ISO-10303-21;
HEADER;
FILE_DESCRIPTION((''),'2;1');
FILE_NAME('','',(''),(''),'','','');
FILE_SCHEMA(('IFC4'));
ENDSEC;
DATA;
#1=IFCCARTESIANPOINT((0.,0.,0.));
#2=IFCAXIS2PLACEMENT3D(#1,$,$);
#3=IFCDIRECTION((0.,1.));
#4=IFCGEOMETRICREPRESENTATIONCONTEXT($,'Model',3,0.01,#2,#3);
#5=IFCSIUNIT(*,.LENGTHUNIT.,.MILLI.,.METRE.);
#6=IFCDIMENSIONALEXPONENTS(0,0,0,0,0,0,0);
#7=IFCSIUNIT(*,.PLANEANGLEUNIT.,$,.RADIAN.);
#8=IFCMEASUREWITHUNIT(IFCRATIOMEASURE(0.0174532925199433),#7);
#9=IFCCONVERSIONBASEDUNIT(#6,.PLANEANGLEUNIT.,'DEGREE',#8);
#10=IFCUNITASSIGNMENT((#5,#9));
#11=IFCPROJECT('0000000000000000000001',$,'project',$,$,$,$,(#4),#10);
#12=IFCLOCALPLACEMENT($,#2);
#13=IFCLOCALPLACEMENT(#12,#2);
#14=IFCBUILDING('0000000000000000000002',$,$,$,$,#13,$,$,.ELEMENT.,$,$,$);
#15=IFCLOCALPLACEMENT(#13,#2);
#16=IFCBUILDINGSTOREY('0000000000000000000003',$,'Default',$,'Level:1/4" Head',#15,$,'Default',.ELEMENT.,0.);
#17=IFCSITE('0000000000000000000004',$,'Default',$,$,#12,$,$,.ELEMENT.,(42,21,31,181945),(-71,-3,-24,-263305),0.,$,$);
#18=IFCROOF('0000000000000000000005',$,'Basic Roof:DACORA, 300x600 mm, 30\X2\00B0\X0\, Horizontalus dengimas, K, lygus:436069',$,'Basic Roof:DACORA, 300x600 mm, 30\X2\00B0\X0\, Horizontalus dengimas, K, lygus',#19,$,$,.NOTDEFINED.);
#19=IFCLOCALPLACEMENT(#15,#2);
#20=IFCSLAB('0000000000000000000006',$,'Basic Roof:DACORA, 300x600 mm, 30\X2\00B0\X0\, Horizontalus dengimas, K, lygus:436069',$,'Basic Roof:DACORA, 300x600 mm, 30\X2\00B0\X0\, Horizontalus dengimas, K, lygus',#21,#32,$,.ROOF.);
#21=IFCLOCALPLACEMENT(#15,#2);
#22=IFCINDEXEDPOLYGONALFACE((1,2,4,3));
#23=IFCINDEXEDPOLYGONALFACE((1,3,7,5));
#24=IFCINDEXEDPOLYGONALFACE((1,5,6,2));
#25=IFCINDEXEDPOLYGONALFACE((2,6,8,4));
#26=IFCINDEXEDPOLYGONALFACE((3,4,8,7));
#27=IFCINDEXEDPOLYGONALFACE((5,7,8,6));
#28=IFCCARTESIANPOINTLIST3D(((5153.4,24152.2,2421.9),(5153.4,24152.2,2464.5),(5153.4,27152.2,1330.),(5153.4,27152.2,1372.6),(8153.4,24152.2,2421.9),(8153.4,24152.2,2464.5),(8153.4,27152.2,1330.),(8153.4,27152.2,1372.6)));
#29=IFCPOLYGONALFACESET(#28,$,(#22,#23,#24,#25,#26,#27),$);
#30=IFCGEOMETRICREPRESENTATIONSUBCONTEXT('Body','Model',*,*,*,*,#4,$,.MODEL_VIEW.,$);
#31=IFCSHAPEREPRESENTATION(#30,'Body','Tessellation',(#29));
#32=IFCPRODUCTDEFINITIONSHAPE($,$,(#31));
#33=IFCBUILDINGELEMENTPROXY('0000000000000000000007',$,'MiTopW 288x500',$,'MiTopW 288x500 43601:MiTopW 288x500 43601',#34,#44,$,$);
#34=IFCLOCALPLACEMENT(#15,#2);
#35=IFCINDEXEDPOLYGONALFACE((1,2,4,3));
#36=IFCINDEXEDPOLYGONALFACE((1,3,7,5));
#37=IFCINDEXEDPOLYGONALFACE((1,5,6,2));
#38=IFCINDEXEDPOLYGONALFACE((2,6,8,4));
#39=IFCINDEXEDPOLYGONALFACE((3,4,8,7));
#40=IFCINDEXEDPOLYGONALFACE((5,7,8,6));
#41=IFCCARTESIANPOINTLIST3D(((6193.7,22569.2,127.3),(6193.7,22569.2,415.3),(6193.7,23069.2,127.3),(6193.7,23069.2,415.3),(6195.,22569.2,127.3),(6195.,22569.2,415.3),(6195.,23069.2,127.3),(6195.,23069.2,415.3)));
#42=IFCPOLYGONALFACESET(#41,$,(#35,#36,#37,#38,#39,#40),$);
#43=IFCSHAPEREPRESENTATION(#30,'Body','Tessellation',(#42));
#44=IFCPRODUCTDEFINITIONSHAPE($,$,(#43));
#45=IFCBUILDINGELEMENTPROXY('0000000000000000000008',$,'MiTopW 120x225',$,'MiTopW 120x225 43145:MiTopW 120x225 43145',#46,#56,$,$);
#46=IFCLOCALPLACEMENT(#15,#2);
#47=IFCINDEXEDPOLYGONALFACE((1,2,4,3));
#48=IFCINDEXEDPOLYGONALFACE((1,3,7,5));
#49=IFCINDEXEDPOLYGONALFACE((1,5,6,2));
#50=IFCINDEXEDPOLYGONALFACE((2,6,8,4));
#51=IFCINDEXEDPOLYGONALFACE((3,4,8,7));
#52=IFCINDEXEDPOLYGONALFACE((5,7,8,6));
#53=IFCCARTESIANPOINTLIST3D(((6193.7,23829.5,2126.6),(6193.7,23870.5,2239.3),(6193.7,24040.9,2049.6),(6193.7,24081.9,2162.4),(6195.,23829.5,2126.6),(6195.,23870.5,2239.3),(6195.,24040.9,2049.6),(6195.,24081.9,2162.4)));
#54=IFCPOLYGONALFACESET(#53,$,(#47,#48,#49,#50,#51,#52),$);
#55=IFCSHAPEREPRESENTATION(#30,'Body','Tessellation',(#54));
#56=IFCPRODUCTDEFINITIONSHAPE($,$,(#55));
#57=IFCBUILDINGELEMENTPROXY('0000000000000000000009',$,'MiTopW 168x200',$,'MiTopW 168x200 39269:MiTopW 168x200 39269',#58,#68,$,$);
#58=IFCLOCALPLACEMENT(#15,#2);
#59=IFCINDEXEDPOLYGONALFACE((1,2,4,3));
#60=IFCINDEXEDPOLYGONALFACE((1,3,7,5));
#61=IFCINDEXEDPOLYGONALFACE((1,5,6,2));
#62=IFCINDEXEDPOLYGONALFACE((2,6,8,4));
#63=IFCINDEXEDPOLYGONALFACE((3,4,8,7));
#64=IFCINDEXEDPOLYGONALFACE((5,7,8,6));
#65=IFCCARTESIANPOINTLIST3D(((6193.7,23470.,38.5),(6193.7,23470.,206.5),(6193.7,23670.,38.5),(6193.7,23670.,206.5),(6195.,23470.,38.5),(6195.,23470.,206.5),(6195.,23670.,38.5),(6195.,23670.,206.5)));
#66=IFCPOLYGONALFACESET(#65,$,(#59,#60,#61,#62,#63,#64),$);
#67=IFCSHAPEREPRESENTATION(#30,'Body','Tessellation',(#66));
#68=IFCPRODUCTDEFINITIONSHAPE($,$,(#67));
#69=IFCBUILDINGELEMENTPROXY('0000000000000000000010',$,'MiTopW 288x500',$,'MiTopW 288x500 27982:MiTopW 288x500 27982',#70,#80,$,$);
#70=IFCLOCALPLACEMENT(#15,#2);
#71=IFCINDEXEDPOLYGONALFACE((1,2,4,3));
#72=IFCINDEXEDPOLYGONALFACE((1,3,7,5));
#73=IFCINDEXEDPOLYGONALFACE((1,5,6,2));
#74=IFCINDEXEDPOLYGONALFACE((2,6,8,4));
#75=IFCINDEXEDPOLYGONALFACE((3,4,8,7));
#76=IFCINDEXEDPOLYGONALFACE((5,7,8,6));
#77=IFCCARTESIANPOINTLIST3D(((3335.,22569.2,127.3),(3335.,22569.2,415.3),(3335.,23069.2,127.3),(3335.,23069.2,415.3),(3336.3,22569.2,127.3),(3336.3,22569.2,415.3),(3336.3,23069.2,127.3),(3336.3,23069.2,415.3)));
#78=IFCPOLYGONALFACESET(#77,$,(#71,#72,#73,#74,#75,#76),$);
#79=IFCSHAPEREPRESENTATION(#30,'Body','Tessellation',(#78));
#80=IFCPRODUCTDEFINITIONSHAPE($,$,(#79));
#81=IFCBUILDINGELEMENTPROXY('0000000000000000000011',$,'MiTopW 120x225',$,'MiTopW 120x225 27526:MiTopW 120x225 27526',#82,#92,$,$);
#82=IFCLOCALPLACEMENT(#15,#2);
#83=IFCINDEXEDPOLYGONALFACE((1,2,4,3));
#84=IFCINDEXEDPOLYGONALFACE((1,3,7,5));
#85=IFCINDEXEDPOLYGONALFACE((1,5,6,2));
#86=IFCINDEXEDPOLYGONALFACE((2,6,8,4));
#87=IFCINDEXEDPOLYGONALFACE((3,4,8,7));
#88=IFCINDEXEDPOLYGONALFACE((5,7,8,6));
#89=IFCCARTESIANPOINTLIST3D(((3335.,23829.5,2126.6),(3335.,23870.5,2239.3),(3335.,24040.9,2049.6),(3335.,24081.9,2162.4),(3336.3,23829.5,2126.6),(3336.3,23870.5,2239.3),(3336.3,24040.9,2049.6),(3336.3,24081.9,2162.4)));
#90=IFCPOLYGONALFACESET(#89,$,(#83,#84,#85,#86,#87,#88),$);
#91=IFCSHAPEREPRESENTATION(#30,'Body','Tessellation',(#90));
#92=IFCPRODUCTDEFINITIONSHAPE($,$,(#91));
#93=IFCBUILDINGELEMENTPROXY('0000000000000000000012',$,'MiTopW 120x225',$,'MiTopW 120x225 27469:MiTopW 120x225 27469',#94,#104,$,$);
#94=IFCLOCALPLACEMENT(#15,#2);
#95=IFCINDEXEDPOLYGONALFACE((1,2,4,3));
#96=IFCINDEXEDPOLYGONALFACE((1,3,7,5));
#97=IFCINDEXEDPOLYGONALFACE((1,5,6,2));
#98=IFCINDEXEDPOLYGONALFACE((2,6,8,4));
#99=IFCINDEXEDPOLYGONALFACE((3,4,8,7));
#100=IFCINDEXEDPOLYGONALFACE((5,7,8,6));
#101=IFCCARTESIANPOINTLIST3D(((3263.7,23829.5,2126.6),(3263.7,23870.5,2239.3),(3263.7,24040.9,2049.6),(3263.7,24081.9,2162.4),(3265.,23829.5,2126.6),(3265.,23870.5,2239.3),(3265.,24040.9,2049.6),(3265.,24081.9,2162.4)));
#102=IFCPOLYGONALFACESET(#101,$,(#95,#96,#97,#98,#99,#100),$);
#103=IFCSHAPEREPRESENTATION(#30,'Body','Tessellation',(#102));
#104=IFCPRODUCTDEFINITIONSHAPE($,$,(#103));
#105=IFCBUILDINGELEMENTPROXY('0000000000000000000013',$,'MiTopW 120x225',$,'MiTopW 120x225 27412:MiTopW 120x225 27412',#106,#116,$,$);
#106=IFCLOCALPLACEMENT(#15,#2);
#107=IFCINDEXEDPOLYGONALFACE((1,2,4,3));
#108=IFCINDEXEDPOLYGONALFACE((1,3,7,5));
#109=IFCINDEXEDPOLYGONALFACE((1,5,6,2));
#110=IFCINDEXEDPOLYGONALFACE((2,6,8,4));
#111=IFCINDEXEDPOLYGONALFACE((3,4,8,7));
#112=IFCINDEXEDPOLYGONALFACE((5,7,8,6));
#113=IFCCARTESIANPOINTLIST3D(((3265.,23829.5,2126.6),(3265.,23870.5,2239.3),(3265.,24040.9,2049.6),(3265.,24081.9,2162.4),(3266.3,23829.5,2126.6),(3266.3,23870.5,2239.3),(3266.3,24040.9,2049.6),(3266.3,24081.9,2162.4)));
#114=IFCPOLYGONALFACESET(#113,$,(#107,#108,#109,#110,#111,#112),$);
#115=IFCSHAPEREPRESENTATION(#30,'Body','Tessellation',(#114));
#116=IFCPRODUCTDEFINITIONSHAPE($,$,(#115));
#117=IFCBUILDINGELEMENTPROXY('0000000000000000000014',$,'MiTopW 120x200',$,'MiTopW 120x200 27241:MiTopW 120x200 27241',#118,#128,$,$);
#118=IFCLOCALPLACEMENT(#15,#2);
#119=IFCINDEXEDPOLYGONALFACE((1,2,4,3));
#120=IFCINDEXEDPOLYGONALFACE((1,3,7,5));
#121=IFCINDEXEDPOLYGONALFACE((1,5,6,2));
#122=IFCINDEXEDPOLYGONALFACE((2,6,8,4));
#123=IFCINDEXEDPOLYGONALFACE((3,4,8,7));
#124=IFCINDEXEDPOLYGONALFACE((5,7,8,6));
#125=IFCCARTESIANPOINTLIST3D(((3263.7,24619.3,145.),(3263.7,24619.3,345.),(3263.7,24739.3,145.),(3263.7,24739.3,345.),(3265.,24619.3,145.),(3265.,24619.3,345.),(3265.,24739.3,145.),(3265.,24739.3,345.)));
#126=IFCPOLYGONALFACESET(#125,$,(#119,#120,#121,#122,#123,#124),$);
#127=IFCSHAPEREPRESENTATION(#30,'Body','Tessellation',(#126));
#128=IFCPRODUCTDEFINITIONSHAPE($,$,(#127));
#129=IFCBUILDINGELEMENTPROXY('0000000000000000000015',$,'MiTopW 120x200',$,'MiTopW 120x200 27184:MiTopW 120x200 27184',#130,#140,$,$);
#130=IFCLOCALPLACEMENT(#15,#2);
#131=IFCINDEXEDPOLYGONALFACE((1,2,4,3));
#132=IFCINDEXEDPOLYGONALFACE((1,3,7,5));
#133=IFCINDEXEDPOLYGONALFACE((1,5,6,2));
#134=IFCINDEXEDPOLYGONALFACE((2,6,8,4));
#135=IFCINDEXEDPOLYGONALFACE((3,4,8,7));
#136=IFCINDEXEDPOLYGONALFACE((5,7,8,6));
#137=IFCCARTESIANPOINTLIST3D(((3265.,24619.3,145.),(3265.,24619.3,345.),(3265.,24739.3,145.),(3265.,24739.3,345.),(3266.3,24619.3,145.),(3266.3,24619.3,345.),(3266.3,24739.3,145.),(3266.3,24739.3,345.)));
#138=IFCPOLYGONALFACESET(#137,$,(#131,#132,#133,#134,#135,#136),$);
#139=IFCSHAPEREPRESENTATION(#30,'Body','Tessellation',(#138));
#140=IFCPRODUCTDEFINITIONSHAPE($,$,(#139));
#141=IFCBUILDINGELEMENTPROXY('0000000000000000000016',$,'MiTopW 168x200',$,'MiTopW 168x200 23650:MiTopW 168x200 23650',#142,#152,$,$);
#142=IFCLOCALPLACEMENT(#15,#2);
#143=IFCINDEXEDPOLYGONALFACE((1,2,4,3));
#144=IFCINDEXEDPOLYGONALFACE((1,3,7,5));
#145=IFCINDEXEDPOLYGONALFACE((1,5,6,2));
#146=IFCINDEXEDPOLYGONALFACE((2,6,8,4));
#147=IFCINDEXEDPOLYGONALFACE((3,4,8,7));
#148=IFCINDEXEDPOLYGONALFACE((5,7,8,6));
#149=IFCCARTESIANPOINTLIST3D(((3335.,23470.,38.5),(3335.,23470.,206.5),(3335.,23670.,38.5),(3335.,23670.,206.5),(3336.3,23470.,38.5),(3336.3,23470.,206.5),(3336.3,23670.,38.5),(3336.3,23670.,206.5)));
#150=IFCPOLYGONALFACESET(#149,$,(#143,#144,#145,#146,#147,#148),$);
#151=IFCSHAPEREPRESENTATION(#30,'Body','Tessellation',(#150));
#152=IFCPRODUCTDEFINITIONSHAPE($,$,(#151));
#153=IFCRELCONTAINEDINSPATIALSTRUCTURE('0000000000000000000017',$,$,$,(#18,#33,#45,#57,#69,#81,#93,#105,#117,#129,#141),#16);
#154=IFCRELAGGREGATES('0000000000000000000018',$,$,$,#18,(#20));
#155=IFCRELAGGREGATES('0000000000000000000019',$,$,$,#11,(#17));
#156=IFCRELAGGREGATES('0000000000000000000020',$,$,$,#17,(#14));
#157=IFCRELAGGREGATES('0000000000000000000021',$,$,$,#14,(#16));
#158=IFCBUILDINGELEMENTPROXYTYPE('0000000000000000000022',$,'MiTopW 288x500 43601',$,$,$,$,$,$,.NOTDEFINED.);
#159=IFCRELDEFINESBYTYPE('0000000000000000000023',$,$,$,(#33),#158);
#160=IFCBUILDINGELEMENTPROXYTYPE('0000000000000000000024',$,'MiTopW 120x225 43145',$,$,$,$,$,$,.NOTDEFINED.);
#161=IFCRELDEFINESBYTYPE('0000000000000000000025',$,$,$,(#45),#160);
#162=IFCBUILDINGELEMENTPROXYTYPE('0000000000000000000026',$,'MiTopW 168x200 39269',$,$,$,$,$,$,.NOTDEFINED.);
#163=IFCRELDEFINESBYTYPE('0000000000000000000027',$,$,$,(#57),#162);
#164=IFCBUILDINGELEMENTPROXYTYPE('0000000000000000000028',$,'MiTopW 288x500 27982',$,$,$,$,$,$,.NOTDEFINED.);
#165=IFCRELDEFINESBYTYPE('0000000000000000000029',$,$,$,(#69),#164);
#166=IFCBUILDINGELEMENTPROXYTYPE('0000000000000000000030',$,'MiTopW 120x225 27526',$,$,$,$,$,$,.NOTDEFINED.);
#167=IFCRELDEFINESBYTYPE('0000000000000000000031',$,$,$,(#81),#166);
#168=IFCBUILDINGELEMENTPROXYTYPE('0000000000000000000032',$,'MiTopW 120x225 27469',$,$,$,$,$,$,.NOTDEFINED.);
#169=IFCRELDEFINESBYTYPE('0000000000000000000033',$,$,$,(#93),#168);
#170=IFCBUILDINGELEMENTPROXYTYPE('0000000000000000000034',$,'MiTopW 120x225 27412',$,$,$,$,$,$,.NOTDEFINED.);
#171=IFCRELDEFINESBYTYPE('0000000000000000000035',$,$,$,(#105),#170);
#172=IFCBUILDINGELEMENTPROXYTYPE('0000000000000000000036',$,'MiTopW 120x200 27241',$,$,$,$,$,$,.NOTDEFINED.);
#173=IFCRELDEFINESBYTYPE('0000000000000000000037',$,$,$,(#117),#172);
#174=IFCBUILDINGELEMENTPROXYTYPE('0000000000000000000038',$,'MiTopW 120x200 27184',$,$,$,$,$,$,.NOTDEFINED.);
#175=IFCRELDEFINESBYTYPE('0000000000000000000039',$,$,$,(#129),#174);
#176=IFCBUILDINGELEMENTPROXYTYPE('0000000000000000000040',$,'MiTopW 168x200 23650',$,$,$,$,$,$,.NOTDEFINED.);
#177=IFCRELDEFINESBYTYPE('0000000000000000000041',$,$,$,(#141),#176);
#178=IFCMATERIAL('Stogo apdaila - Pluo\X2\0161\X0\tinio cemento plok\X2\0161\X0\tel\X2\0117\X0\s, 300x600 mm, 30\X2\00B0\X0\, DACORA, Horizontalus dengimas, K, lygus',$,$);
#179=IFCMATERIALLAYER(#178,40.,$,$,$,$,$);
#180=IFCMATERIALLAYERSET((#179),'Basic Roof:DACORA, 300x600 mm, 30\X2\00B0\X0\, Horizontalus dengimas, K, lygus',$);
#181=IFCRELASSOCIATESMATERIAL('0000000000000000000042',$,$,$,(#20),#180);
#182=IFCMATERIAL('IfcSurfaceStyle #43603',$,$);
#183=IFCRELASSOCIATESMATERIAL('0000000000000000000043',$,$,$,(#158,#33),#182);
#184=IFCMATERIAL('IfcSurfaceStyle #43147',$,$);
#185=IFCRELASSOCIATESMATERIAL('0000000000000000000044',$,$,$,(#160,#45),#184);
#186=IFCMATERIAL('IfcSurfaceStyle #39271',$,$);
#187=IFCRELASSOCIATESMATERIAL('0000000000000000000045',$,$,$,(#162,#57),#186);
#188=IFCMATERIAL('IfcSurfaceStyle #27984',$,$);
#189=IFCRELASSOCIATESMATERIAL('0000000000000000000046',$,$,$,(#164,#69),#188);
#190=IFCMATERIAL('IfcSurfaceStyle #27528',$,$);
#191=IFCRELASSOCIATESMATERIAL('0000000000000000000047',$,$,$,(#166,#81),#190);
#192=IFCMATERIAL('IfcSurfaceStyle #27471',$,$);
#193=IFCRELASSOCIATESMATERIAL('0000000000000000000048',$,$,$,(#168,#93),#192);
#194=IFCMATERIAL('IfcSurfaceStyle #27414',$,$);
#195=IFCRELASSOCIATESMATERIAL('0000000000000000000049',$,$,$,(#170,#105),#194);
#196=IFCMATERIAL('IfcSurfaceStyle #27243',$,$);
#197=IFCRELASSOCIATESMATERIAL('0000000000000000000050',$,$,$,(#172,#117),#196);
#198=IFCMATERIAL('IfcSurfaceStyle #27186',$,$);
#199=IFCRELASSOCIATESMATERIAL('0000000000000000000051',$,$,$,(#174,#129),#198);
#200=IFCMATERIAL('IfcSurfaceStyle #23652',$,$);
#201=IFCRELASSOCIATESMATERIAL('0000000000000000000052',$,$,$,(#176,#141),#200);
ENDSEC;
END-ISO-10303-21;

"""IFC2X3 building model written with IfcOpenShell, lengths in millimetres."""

from ifc_helpers import new_model, entity, si_unit, converted_unit, direction, frame, frame_2d, origin, origin_2d_with_axis, place, context, subcontext, project, spatial, polyline, rectangle, outline, extrude, source, transform, mapped, material, layer, layer_set, type_object, type_shapes, element, aggregate, save


model = new_model("IFC2X3")

# Units and contexts
model_context = context("Model", 3, precision=0.01, world=origin(), true_north=direction((0.0, 1.0)))
body_context = subcontext(model_context, "Body", "Model", "MODEL_VIEW")
ifc_project = project(units=[si_unit("LENGTHUNIT", "METRE", prefix="MILLI"), converted_unit("PLANEANGLEUNIT", "DEGREE", entity("IfcRatioMeasure", 0.0174532925199433), si_unit("PLANEANGLEUNIT", "RADIAN"), dimensions=[0, 0, 0, 0, 0, 0, 0])], contexts=[model_context])

# Site, building, storey
site_placement = place(None, origin())
site = spatial("IfcSite", under=ifc_project, at=site_placement, Name="Default", CompositionType="ELEMENT", RefLatitude=(42, 21, 31, 181945), RefLongitude=(-71, -3, -24, -263305), RefElevation=0.0)
building_placement = place(site_placement, origin())
building = spatial("IfcBuilding", under=site, at=building_placement, CompositionType="ELEMENT")
storey_placement = place(building_placement, origin())
storey = spatial("IfcBuildingStorey", under=building, at=storey_placement, Name="Default", ObjectType="Level:1/4\" Head", LongName="Default", CompositionType="ELEMENT", Elevation=0.0)

# Roof, slab
roof_placement = place(storey_placement, frame((5153.4, 24152.2, 1330.0)))
roof = element("IfcRoof", 1, at=roof_placement, inside=storey, Name="Basic Roof:DACORA, 300x600 mm, 30°, Horizontalus dengimas, K, lygus:436069", ObjectType="Basic Roof:DACORA, 300x600 mm, 30°, Horizontalus dengimas, K, lygus", ShapeType="NOTDEFINED")
ifc_material_1 = material(Name="Stogo apdaila - Pluoštinio cemento plokštelės, 300x600 mm, 30°, DACORA, Horizontalus dengimas, K, lygus")
ifc_layer = layer(ifc_material_1, 40.0)
ifc_layer_set = layer_set([ifc_layer], Name="Basic Roof:DACORA, 300x600 mm, 30°, Horizontalus dengimas, K, lygus")
slab_placement = place(roof_placement, origin())
slab = element("IfcSlab", 2, at=slab_placement, material=ifc_layer_set, Name="Basic Roof:DACORA, 300x600 mm, 30°, Horizontalus dengimas, K, lygus:436069", ObjectType="Basic Roof:DACORA, 300x600 mm, 30°, Horizontalus dengimas, K, lygus", PredefinedType="ROOF", context=body_context, shape_type="SweptSolid", body=[
    extrude(rectangle(XDim=3192.5, YDim=3000.0, at=frame_2d((0.0, 0.0), x_axis=(0.0, 1.0))), frame((1500.0, 1500.0, 546.0), z_axis=(0.0, 0.34202, 0.939693), x_axis=(1.0, 0.0, 0.0)), (0.0, -0.34202, 0.939693), 42.6),
])
aggregate(roof, [slab])

# Building element proxies
ifc_material_2 = material(Name="IfcSurfaceStyle #43603")
building_element_proxy_type_1 = type_object("IfcBuildingElementProxyType", Name="MiTopW 288x500 43601", PredefinedType="NOTDEFINED", material=ifc_material_2)
shared_shape_1 = source(origin(), body_context, "Body", "SweptSolid", [
    extrude(rectangle(XDim=500.0, YDim=288.0, at=origin_2d_with_axis()), frame((250.0, 144.0, 0.0), z_axis=(0.0, 0.0, 1.0), x_axis=(-1.0, 0.0, 0.0)), (0.0, 0.0, 1.0), 1.3),
])
type_shapes(building_element_proxy_type_1, [shared_shape_1])
proxy_1_placement = place(building_placement, frame((6195.0, 23069.2, 127.3), z_axis=(-1.0, 0.0, 0.0), x_axis=(0.0, -1.0, 0.0)))
element("IfcBuildingElementProxy", 3, at=proxy_1_placement, inside=storey, type_object=building_element_proxy_type_1, material=ifc_material_2, Name="MiTopW 288x500", ObjectType="MiTopW 288x500 43601:MiTopW 288x500 43601", context=body_context, shape_type="MappedRepresentation", body=[
    mapped(shared_shape_1, transform((0.0, 0.0, 0.0), scale=1.0)),
])
ifc_material_3 = material(Name="IfcSurfaceStyle #43147")
building_element_proxy_type_2 = type_object("IfcBuildingElementProxyType", Name="MiTopW 120x225 43145", PredefinedType="NOTDEFINED", material=ifc_material_3)
shared_shape_2 = source(origin(), body_context, "Body", "SweptSolid", [
    extrude(outline(polyline([(-112.5, -60.0), (112.5, -60.0), (112.5, 60.0), (-112.5, 60.0), (-112.5, -60.0)])), frame((112.5, 60.0, 0.0), z_axis=(0.0, 0.0, 1.0), x_axis=(-1.0, 0.0, 0.0)), (0.0, 0.0, 1.0), 1.3),
])
type_shapes(building_element_proxy_type_2, [shared_shape_2])
proxy_2_placement = place(building_placement, frame((6195.0, 24040.9, 2049.6), z_axis=(-1.0, 0.0, 0.0), x_axis=(0.0, -0.939693, 0.34202)))
element("IfcBuildingElementProxy", 4, at=proxy_2_placement, inside=storey, type_object=building_element_proxy_type_2, material=ifc_material_3, Name="MiTopW 120x225", ObjectType="MiTopW 120x225 43145:MiTopW 120x225 43145", context=body_context, shape_type="MappedRepresentation", body=[
    mapped(shared_shape_2, transform((0.0, 0.0, 0.0), scale=1.0)),
])
ifc_material_4 = material(Name="IfcSurfaceStyle #39271")
building_element_proxy_type_3 = type_object("IfcBuildingElementProxyType", Name="MiTopW 168x200 39269", PredefinedType="NOTDEFINED", material=ifc_material_4)
shared_shape_3 = source(origin(), body_context, "Body", "SweptSolid", [
    extrude(rectangle(XDim=200.0, YDim=168.0, at=origin_2d_with_axis()), frame((100.0, 84.0, 0.0), z_axis=(0.0, 0.0, 1.0), x_axis=(-1.0, 0.0, 0.0)), (0.0, 0.0, 1.0), 1.3),
])
type_shapes(building_element_proxy_type_3, [shared_shape_3])
proxy_3_placement = place(building_placement, frame((6195.0, 23470.0, 206.5), z_axis=(-1.0, 0.0, 0.0), x_axis=(0.0, 1.0, 0.0)))
element("IfcBuildingElementProxy", 5, at=proxy_3_placement, inside=storey, type_object=building_element_proxy_type_3, material=ifc_material_4, Name="MiTopW 168x200", ObjectType="MiTopW 168x200 39269:MiTopW 168x200 39269", context=body_context, shape_type="MappedRepresentation", body=[
    mapped(shared_shape_3, transform((0.0, 0.0, 0.0), scale=1.0)),
])
ifc_material_5 = material(Name="IfcSurfaceStyle #27984")
building_element_proxy_type_4 = type_object("IfcBuildingElementProxyType", Name="MiTopW 288x500 27982", PredefinedType="NOTDEFINED", material=ifc_material_5)
shared_shape_4 = source(origin(), body_context, "Body", "SweptSolid", [
    extrude(rectangle(XDim=500.0, YDim=288.0, at=origin_2d_with_axis()), frame((250.0, 144.0, 0.0), z_axis=(0.0, 0.0, 1.0), x_axis=(-1.0, 0.0, 0.0)), (0.0, 0.0, 1.0), 1.3),
])
type_shapes(building_element_proxy_type_4, [shared_shape_4])
proxy_4_placement = place(building_placement, frame((3336.3, 23069.2, 127.3), z_axis=(-1.0, 0.0, 0.0), x_axis=(0.0, -1.0, 0.0)))
element("IfcBuildingElementProxy", 6, at=proxy_4_placement, inside=storey, type_object=building_element_proxy_type_4, material=ifc_material_5, Name="MiTopW 288x500", ObjectType="MiTopW 288x500 27982:MiTopW 288x500 27982", context=body_context, shape_type="MappedRepresentation", body=[
    mapped(shared_shape_4, transform((0.0, 0.0, 0.0), scale=1.0)),
])
ifc_material_6 = material(Name="IfcSurfaceStyle #27528")
building_element_proxy_type_5 = type_object("IfcBuildingElementProxyType", Name="MiTopW 120x225 27526", PredefinedType="NOTDEFINED", material=ifc_material_6)
shared_shape_5 = source(origin(), body_context, "Body", "SweptSolid", [
    extrude(outline(polyline([(-112.5, -60.0), (112.5, -60.0), (112.5, 60.0), (-112.5, 60.0), (-112.5, -60.0)])), frame((112.5, 60.0, 0.0), z_axis=(0.0, 0.0, 1.0), x_axis=(-1.0, 0.0, 0.0)), (0.0, 0.0, 1.0), 1.3),
])
type_shapes(building_element_proxy_type_5, [shared_shape_5])
proxy_5_placement = place(building_placement, frame((3336.3, 24040.9, 2049.6), z_axis=(-1.0, 0.0, 0.0), x_axis=(0.0, -0.939693, 0.34202)))
element("IfcBuildingElementProxy", 7, at=proxy_5_placement, inside=storey, type_object=building_element_proxy_type_5, material=ifc_material_6, Name="MiTopW 120x225", ObjectType="MiTopW 120x225 27526:MiTopW 120x225 27526", context=body_context, shape_type="MappedRepresentation", body=[
    mapped(shared_shape_5, transform((0.0, 0.0, 0.0), scale=1.0)),
])
ifc_material_7 = material(Name="IfcSurfaceStyle #27471")
building_element_proxy_type_6 = type_object("IfcBuildingElementProxyType", Name="MiTopW 120x225 27469", PredefinedType="NOTDEFINED", material=ifc_material_7)
shared_shape_6 = source(origin(), body_context, "Body", "SweptSolid", [
    extrude(outline(polyline([(-112.5, -60.0), (112.5, -60.0), (112.5, 60.0), (-112.5, 60.0), (-112.5, -60.0)])), frame((112.5, 60.0, 0.0), z_axis=(0.0, 0.0, 1.0), x_axis=(-1.0, 0.0, 0.0)), (0.0, 0.0, 1.0), 1.3),
])
type_shapes(building_element_proxy_type_6, [shared_shape_6])
proxy_6_placement = place(building_placement, frame((3265.0, 24040.9, 2049.6), z_axis=(-1.0, 0.0, 0.0), x_axis=(0.0, -0.939693, 0.34202)))
element("IfcBuildingElementProxy", 8, at=proxy_6_placement, inside=storey, type_object=building_element_proxy_type_6, material=ifc_material_7, Name="MiTopW 120x225", ObjectType="MiTopW 120x225 27469:MiTopW 120x225 27469", context=body_context, shape_type="MappedRepresentation", body=[
    mapped(shared_shape_6, transform((0.0, 0.0, 0.0), scale=1.0)),
])
ifc_material_8 = material(Name="IfcSurfaceStyle #27414")
building_element_proxy_type_7 = type_object("IfcBuildingElementProxyType", Name="MiTopW 120x225 27412", PredefinedType="NOTDEFINED", material=ifc_material_8)
shared_shape_7 = source(origin(), body_context, "Body", "SweptSolid", [
    extrude(outline(polyline([(-112.5, -60.0), (112.5, -60.0), (112.5, 60.0), (-112.5, 60.0), (-112.5, -60.0)])), frame((112.5, 60.0, 0.0), z_axis=(0.0, 0.0, 1.0), x_axis=(-1.0, 0.0, 0.0)), (0.0, 0.0, 1.0), 1.3),
])
type_shapes(building_element_proxy_type_7, [shared_shape_7])
proxy_7_placement = place(building_placement, frame((3266.3, 24040.9, 2049.6), z_axis=(-1.0, 0.0, 0.0), x_axis=(0.0, -0.939693, 0.34202)))
element("IfcBuildingElementProxy", 9, at=proxy_7_placement, inside=storey, type_object=building_element_proxy_type_7, material=ifc_material_8, Name="MiTopW 120x225", ObjectType="MiTopW 120x225 27412:MiTopW 120x225 27412", context=body_context, shape_type="MappedRepresentation", body=[
    mapped(shared_shape_7, transform((0.0, 0.0, 0.0), scale=1.0)),
])
ifc_material_9 = material(Name="IfcSurfaceStyle #27243")
building_element_proxy_type_8 = type_object("IfcBuildingElementProxyType", Name="MiTopW 120x200 27241", PredefinedType="NOTDEFINED", material=ifc_material_9)
shared_shape_8 = source(origin(), body_context, "Body", "SweptSolid", [
    extrude(rectangle(XDim=200.0, YDim=120.0, at=origin_2d_with_axis()), frame((100.0, 60.0, 0.0), z_axis=(0.0, 0.0, 1.0), x_axis=(-1.0, 0.0, 0.0)), (0.0, 0.0, 1.0), 1.3),
])
type_shapes(building_element_proxy_type_8, [shared_shape_8])
proxy_8_placement = place(building_placement, frame((3265.0, 24619.3, 145.0), z_axis=(-1.0, 0.0, 0.0), x_axis=(0.0, 0.0, 1.0)))
element("IfcBuildingElementProxy", 10, at=proxy_8_placement, inside=storey, type_object=building_element_proxy_type_8, material=ifc_material_9, Name="MiTopW 120x200", ObjectType="MiTopW 120x200 27241:MiTopW 120x200 27241", context=body_context, shape_type="MappedRepresentation", body=[
    mapped(shared_shape_8, transform((0.0, 0.0, 0.0), scale=1.0)),
])
ifc_material_10 = material(Name="IfcSurfaceStyle #27186")
building_element_proxy_type_9 = type_object("IfcBuildingElementProxyType", Name="MiTopW 120x200 27184", PredefinedType="NOTDEFINED", material=ifc_material_10)
shared_shape_9 = source(origin(), body_context, "Body", "SweptSolid", [
    extrude(rectangle(XDim=200.0, YDim=120.0, at=origin_2d_with_axis()), frame((100.0, 60.0, 0.0), z_axis=(0.0, 0.0, 1.0), x_axis=(-1.0, 0.0, 0.0)), (0.0, 0.0, 1.0), 1.3),
])
type_shapes(building_element_proxy_type_9, [shared_shape_9])
proxy_9_placement = place(building_placement, frame((3266.3, 24619.3, 145.0), z_axis=(-1.0, 0.0, 0.0), x_axis=(0.0, 0.0, 1.0)))
element("IfcBuildingElementProxy", 11, at=proxy_9_placement, inside=storey, type_object=building_element_proxy_type_9, material=ifc_material_10, Name="MiTopW 120x200", ObjectType="MiTopW 120x200 27184:MiTopW 120x200 27184", context=body_context, shape_type="MappedRepresentation", body=[
    mapped(shared_shape_9, transform((0.0, 0.0, 0.0), scale=1.0)),
])
ifc_material_11 = material(Name="IfcSurfaceStyle #23652")
building_element_proxy_type_10 = type_object("IfcBuildingElementProxyType", Name="MiTopW 168x200 23650", PredefinedType="NOTDEFINED", material=ifc_material_11)
shared_shape_10 = source(origin(), body_context, "Body", "SweptSolid", [
    extrude(rectangle(XDim=200.0, YDim=168.0, at=origin_2d_with_axis()), frame((100.0, 84.0, 0.0), z_axis=(0.0, 0.0, 1.0), x_axis=(-1.0, 0.0, 0.0)), (0.0, 0.0, 1.0), 1.3),
])
type_shapes(building_element_proxy_type_10, [shared_shape_10])
proxy_10_placement = place(building_placement, frame((3336.3, 23470.0, 206.5), z_axis=(-1.0, 0.0, 0.0), x_axis=(0.0, 1.0, 0.0)))
element("IfcBuildingElementProxy", 12, at=proxy_10_placement, inside=storey, type_object=building_element_proxy_type_10, material=ifc_material_11, Name="MiTopW 168x200", ObjectType="MiTopW 168x200 23650:MiTopW 168x200 23650", context=body_context, shape_type="MappedRepresentation", body=[
    mapped(shared_shape_10, transform((0.0, 0.0, 0.0), scale=1.0)),
])

save(model, "model.ifc")
